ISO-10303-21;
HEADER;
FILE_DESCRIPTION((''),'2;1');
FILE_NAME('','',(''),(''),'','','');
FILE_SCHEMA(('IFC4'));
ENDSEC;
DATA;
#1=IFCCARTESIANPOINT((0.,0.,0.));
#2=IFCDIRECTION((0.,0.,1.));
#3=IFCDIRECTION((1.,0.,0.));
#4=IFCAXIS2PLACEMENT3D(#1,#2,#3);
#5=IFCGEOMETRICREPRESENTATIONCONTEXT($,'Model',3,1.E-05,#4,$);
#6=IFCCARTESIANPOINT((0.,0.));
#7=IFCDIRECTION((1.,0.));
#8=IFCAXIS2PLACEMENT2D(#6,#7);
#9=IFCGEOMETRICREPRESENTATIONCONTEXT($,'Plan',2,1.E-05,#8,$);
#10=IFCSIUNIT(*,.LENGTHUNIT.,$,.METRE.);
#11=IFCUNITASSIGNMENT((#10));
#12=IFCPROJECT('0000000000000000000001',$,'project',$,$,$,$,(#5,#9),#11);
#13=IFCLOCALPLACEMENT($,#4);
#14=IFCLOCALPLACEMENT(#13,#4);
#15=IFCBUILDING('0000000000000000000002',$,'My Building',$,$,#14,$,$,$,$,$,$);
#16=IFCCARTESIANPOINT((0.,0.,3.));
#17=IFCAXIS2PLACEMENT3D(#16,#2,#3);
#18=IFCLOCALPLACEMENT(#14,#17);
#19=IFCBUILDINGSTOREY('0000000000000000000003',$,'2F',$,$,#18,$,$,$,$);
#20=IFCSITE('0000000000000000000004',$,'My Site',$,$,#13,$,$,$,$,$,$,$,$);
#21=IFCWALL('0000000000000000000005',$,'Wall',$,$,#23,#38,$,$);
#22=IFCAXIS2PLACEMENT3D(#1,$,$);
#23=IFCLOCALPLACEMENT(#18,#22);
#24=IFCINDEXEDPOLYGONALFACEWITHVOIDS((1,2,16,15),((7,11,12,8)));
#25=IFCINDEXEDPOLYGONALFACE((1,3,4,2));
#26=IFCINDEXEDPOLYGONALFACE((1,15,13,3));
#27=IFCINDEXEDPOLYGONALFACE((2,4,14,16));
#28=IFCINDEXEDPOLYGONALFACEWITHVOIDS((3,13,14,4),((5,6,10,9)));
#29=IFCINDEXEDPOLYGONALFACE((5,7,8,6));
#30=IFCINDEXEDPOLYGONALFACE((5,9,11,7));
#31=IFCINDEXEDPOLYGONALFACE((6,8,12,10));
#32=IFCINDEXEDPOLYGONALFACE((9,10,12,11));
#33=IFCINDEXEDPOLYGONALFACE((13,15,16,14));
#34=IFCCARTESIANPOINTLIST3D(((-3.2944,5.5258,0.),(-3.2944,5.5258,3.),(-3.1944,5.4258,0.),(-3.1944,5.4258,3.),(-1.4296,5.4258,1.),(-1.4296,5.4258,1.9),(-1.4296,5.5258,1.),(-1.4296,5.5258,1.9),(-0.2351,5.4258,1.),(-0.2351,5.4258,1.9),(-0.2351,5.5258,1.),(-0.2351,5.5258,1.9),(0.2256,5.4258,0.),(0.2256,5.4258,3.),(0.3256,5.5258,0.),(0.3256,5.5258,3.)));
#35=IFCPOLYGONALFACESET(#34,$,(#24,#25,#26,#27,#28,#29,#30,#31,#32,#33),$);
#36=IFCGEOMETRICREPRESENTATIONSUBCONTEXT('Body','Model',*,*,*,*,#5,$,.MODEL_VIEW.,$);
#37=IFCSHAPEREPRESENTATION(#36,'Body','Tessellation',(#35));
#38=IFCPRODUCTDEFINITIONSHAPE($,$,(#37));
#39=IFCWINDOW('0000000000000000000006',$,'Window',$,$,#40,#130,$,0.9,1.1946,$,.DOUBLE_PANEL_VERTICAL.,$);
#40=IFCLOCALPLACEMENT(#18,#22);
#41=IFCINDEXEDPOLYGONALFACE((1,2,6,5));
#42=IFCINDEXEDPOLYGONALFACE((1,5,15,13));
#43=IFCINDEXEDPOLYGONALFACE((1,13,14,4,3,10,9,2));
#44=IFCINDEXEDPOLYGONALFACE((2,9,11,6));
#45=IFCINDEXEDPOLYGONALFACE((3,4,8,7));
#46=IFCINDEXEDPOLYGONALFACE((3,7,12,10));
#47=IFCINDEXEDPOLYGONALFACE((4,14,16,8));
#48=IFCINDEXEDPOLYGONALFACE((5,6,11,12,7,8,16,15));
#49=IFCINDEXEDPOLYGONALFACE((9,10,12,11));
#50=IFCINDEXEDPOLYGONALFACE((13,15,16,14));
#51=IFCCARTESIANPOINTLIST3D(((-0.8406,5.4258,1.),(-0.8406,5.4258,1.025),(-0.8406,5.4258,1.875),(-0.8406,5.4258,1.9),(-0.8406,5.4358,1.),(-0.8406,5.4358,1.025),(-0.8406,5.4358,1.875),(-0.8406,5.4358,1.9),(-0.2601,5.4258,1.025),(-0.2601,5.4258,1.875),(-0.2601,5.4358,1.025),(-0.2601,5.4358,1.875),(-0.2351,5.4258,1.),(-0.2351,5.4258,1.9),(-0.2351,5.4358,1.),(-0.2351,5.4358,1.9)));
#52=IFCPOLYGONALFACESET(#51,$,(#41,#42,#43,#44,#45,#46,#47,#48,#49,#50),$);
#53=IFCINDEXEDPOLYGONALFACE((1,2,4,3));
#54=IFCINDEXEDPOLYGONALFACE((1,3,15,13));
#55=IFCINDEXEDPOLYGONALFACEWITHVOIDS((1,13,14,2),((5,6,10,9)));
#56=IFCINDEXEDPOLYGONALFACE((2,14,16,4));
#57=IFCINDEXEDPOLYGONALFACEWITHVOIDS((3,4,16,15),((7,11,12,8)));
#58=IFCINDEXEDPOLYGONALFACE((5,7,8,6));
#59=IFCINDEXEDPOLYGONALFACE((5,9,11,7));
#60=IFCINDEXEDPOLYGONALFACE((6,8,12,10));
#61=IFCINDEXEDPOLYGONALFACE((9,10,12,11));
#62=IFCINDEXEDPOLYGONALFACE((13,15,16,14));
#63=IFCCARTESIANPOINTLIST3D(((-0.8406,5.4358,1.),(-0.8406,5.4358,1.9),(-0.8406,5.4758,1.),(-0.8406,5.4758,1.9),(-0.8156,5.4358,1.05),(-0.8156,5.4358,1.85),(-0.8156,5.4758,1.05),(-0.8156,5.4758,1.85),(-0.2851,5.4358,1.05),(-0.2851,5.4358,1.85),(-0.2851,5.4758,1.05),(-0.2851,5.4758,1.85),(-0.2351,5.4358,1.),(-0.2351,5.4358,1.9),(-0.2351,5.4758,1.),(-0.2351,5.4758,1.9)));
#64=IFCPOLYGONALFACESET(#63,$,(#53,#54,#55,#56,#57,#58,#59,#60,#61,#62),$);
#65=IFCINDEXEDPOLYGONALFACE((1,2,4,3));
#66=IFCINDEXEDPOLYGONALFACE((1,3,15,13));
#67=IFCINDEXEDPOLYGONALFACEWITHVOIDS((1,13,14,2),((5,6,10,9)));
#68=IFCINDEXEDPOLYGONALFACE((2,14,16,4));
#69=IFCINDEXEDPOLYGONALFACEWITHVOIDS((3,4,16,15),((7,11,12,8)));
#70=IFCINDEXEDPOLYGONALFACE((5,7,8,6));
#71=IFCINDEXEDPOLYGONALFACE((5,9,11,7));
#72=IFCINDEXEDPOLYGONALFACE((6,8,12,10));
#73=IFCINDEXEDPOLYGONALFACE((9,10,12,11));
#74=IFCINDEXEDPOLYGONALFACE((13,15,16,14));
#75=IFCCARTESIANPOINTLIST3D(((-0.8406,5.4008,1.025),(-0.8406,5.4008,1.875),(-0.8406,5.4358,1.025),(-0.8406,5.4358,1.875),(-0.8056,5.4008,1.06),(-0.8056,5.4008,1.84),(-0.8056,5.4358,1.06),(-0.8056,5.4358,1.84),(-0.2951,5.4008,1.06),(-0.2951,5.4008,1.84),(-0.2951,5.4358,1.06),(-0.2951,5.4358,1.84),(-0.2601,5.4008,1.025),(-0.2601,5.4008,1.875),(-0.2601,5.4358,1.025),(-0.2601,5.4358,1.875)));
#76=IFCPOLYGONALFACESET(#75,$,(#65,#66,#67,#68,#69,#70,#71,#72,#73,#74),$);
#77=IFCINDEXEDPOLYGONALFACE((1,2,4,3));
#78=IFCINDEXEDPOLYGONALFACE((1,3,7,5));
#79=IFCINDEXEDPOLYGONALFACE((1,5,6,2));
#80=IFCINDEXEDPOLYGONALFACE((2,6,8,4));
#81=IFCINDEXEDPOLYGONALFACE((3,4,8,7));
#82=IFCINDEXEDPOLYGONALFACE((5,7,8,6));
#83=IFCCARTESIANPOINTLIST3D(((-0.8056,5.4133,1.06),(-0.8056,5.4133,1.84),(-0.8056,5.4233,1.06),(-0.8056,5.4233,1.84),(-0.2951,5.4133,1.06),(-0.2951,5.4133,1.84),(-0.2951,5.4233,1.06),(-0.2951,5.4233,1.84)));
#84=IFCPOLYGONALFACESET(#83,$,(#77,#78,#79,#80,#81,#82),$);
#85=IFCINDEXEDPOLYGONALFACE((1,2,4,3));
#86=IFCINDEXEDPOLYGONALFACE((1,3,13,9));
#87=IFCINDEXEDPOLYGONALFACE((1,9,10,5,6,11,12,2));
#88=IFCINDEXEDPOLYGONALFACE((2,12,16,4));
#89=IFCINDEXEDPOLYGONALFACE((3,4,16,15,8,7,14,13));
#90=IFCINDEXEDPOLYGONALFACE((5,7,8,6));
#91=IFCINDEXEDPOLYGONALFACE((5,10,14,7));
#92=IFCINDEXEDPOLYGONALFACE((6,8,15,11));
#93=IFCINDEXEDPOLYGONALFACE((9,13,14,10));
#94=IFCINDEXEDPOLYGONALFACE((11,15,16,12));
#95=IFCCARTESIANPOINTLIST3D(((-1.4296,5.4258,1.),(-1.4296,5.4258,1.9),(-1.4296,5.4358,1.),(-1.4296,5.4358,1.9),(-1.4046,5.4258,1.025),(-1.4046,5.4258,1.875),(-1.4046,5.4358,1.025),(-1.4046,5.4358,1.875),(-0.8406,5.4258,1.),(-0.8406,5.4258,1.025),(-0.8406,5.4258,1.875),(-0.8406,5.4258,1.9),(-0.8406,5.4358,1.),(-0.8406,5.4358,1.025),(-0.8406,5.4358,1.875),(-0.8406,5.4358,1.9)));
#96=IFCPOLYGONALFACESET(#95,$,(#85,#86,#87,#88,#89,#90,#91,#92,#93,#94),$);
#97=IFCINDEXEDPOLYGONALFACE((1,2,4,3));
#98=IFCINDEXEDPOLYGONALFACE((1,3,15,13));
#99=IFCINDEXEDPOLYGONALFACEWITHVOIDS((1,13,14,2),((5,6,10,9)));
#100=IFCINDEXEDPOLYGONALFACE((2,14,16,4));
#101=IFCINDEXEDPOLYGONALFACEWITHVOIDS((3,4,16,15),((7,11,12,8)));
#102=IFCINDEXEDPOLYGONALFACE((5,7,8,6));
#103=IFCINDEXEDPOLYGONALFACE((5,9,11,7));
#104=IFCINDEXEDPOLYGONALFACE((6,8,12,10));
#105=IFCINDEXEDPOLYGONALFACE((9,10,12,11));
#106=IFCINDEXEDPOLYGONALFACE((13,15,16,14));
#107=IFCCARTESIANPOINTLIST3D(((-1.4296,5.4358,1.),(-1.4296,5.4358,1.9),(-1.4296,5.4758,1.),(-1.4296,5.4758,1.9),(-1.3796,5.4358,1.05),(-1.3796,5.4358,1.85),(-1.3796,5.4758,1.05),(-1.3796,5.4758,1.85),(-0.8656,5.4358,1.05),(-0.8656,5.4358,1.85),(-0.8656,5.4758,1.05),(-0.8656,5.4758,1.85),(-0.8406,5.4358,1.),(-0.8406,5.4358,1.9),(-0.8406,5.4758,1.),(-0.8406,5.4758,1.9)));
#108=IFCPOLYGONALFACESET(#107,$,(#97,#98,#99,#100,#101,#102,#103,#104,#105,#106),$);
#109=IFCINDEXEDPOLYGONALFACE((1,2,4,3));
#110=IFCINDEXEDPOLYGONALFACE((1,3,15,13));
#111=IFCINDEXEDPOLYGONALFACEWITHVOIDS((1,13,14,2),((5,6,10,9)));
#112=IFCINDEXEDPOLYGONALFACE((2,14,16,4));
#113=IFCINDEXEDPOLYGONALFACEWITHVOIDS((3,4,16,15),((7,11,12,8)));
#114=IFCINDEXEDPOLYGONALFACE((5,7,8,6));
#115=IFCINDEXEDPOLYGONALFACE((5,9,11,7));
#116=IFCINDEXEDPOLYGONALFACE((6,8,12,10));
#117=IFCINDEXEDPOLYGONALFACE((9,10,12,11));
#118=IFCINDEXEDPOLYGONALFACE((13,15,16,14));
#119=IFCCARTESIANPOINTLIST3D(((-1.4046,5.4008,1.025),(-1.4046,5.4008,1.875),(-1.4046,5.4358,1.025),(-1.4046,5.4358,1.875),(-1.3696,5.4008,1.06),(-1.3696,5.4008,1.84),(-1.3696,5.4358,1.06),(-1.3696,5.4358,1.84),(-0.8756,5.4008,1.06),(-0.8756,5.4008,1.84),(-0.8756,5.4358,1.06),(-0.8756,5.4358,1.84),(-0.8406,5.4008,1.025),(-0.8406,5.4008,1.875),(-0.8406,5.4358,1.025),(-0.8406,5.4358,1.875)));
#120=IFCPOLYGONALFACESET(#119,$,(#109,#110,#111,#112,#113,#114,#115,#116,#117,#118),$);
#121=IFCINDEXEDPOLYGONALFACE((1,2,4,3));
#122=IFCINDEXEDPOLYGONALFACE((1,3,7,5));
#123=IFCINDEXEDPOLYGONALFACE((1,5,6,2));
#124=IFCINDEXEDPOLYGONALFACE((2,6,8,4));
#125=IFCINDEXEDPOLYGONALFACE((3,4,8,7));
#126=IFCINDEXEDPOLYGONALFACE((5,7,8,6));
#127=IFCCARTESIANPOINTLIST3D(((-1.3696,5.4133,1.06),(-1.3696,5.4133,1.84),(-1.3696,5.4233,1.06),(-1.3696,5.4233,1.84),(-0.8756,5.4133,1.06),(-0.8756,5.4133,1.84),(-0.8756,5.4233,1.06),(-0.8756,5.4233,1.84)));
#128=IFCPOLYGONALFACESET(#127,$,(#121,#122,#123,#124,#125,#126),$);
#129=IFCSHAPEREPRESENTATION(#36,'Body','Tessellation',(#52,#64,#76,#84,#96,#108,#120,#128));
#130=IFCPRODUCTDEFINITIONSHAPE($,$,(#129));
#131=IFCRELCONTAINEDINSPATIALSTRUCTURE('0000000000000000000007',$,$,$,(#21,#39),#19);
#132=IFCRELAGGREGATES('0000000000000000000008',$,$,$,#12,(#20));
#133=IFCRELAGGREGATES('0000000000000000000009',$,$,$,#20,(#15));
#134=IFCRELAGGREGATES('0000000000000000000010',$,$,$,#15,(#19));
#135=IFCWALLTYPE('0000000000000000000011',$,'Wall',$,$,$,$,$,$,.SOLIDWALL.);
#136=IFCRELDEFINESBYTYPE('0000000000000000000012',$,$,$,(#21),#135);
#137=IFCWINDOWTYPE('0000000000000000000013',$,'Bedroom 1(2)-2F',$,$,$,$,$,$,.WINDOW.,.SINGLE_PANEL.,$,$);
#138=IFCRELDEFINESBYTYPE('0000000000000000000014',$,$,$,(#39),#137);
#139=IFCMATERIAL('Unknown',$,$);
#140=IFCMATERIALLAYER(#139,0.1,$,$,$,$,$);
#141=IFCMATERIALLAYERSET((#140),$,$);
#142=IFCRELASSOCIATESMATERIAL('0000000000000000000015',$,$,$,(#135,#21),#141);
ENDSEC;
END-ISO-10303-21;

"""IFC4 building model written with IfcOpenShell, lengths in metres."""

from ifc_helpers import new_model, entity, si_unit, frame, origin_with_axes, origin_2d_with_axis, place, context, subcontext, project, spatial, line, indexed_curve, outline, extrude, shape, source, transform, mapped, material, layer, layer_set, layer_usage, type_object, type_shapes, element, fill, save


model = new_model("IFC4")

# Units and contexts
model_context = context("Model", 3, precision=1e-05, world=origin_with_axes())
plan_context = context("Plan", 2, precision=1e-05, world=origin_2d_with_axis())
body_context_1 = subcontext(model_context, "Body", "Model", "MODEL_VIEW")
body_context_2 = subcontext(plan_context, "Body", "Plan", "PLAN_VIEW")
ifc_project = project(units=[si_unit("LENGTHUNIT", "METRE")], contexts=[model_context, plan_context])

# Site, building, storey
site_placement = place(None, origin_with_axes())
site = spatial("IfcSite", under=ifc_project, at=site_placement, Name="My Site")
building_placement = place(site_placement, origin_with_axes())
building = spatial("IfcBuilding", under=site, at=building_placement, Name="My Building")
storey_placement = place(building_placement, frame((0.0, 0.0, 3.0), z_axis=(0.0, 0.0, 1.0), x_axis=(1.0, 0.0, 0.0)))
storey = spatial("IfcBuildingStorey", under=building, at=storey_placement, Name="2F")

# Shared definitions
ifc_material = material(Name="Unknown")

# Shared definitions
ifc_layer = layer(ifc_material, 0.1)
ifc_layer_set = layer_set([ifc_layer])
wall_type = type_object("IfcWallType", Name="Wall", PredefinedType="SOLIDWALL", material=ifc_layer_set)

# Wall, opening, window
ifc_layer_usage_1 = layer_usage(ifc_layer_set, "AXIS2", "POSITIVE", 0.0)
wall_1_placement = place(storey_placement, frame((0.2256, 5.5258, 0.0), z_axis=(0.0, 0.0, 1.0), x_axis=(-1.0, 0.0, 0.0)))
wall_1 = element("IfcWall", 1, at=wall_1_placement, inside=storey, type_object=wall_type, material=ifc_layer_usage_1, Name="Wall", context=body_context_1, shape_type="SweptSolid", body=[
    extrude(outline(indexed_curve([(-0.1, 0.0), (0.0, 0.1), (3.42, 0.1), (3.52, 0.0)], segments=[line(1, 2, 3, 4, 1)])), origin_with_axes(), (0.0, 0.0, 1.0), 3.0),
])
shared_shape_1 = source(origin_with_axes(), body_context_1, "Body", "SweptSolid", [
    extrude(outline(indexed_curve([(0.0, 0.0), (1.1946, 0.0), (1.1946, 0.9), (0.0, 0.9)], segments=[line(1, 2, 3, 4, 1)])), frame((0.0, -0.6, 0.0), z_axis=(0.0, -1.0, 0.0), x_axis=(1.0, 0.0, 0.0)), (0.0, 0.0, -1.0), 1.2),
])
opening_1_placement = place(wall_1_placement, frame((0.4607, 0.0, 1.0), z_axis=(0.0, 0.0, 1.0), x_axis=(1.0, 0.0, 0.0)))
opening_1 = element("IfcOpeningElement", 2, at=opening_1_placement, cuts=wall_1, PredefinedType="OPENING", context=body_context_1, shape_type="MappedRepresentation", body=[
    mapped(shared_shape_1, transform((0.0, 0.0, 0.0), x_axis=(1.0, 0.0, 0.0), y_axis=(0.0, 1.0, 0.0), z_axis=(0.0, 0.0, 1.0), scale=1.0)),
])
window_type_1 = type_object("IfcWindowType", Name="Bedroom 1(2)-2F", PartitioningType="SINGLE_PANEL", PredefinedType="WINDOW")
shared_shape_2 = source(origin_with_axes(), body_context_1, "Body", "SweptSolid", [
    extrude(outline(indexed_curve([(0.6056, 0.0), (0.0, 0.0), (0.0, 0.9), (0.6056, 0.9), (0.6056, 0.875), (0.025, 0.875), (0.025, 0.025), (0.6056, 0.025)], segments=[line(1, 2, 3, 4, 5, 6, 7, 8, 1)])), frame((0.0, 0.09, 0.0), z_axis=(0.0, -1.0, 0.0), x_axis=(1.0, 0.0, 0.0)), (0.0, 0.0, -1.0), 0.01),
    extrude(outline(indexed_curve([(0.0, 0.0), (0.6056, 0.0), (0.6056, 0.9), (0.0, 0.9)], segments=[line(1, 2, 3, 4, 1)]), holes=[indexed_curve([(0.05, 0.05), (0.5806, 0.05), (0.5806, 0.85), (0.05, 0.85)], segments=[line(1, 2, 3, 4, 1)])]), frame((0.0, 0.05, 0.0), z_axis=(0.0, -1.0, 0.0), x_axis=(1.0, 0.0, 0.0)), (0.0, 0.0, -1.0), 0.04),
    extrude(outline(indexed_curve([(0.0, 0.0), (0.5806, 0.0), (0.5806, 0.85), (0.0, 0.85)], segments=[line(1, 2, 3, 4, 1)]), holes=[indexed_curve([(0.035, 0.035), (0.5456, 0.035), (0.5456, 0.815), (0.035, 0.815)], segments=[line(1, 2, 3, 4, 1)])]), frame((0.025, 0.09, 0.025), z_axis=(0.0, -1.0, 0.0), x_axis=(1.0, 0.0, 0.0)), (0.0, 0.0, -1.0), 0.035),
    extrude(outline(indexed_curve([(0.035, 0.035), (0.5456, 0.035), (0.5456, 0.815), (0.035, 0.815)], segments=[line(1, 2, 3, 4, 1)])), frame((0.025, 0.1025, 0.025), z_axis=(0.0, -1.0, 0.0), x_axis=(1.0, 0.0, 0.0)), (0.0, 0.0, -1.0), 0.01),
    extrude(outline(indexed_curve([(0.0, 0.9), (0.589, 0.9), (0.589, 0.0), (0.0, 0.0), (0.0, 0.025), (0.564, 0.025), (0.564, 0.875), (0.0, 0.875)], segments=[line(1, 2, 3, 4, 5, 6, 7, 8, 1)])), frame((0.6056, 0.09, 0.0), z_axis=(0.0, -1.0, 0.0), x_axis=(1.0, 0.0, 0.0)), (0.0, 0.0, -1.0), 0.01),
    extrude(outline(indexed_curve([(0.0, 0.0), (0.589, 0.0), (0.589, 0.9), (0.0, 0.9)], segments=[line(1, 2, 3, 4, 1)]), holes=[indexed_curve([(0.025, 0.05), (0.539, 0.05), (0.539, 0.85), (0.025, 0.85)], segments=[line(1, 2, 3, 4, 1)])]), frame((0.6056, 0.05, 0.0), z_axis=(0.0, -1.0, 0.0), x_axis=(1.0, 0.0, 0.0)), (0.0, 0.0, -1.0), 0.04),
    extrude(outline(indexed_curve([(0.0, 0.0), (0.564, 0.0), (0.564, 0.85), (0.0, 0.85)], segments=[line(1, 2, 3, 4, 1)]), holes=[indexed_curve([(0.035, 0.035), (0.529, 0.035), (0.529, 0.815), (0.035, 0.815)], segments=[line(1, 2, 3, 4, 1)])]), frame((0.6056, 0.09, 0.025), z_axis=(0.0, -1.0, 0.0), x_axis=(1.0, 0.0, 0.0)), (0.0, 0.0, -1.0), 0.035),
    extrude(outline(indexed_curve([(0.035, 0.035), (0.529, 0.035), (0.529, 0.815), (0.035, 0.815)], segments=[line(1, 2, 3, 4, 1)])), frame((0.6056, 0.1025, 0.025), z_axis=(0.0, -1.0, 0.0), x_axis=(1.0, 0.0, 0.0)), (0.0, 0.0, -1.0), 0.01),
])
shared_shape_3 = source(origin_with_axes(), body_context_2, "Body", "Curve2D", [
    entity("IfcIndexedPolyCurve", entity("IfcCartesianPointList2D", [[0.05, 0.05], [0.5806, 0.05]])),
    entity("IfcIndexedPolyCurve", entity("IfcCartesianPointList2D", [[0.0, 0.1], [0.025, 0.1], [0.025, 0.09], [0.05, 0.09], [0.05, 0.05], [0.0, 0.05]]), [entity("IfcLineIndex", [1, 2, 3, 4, 5, 6, 1])]),
    entity("IfcIndexedPolyCurve", entity("IfcCartesianPointList2D", [[0.6056, 0.1], [0.6056, 0.1], [0.6056, 0.09], [0.5806, 0.09], [0.5806, 0.05], [0.6056, 0.05]])),
    entity("IfcIndexedPolyCurve", entity("IfcCartesianPointList2D", [[0.025, 0.09], [0.06, 0.09], [0.06, 0.125], [0.025, 0.125]]), [entity("IfcLineIndex", [1, 2, 3, 4, 1])]),
    entity("IfcIndexedPolyCurve", entity("IfcCartesianPointList2D", [[0.6056, 0.09], [0.5706, 0.09], [0.5706, 0.125], [0.6056, 0.125]]), [entity("IfcLineIndex", [1, 2, 3, 4, 1])]),
    entity("IfcIndexedPolyCurve", entity("IfcCartesianPointList2D", [[0.06, 0.09], [0.5706, 0.09]])),
    entity("IfcIndexedPolyCurve", entity("IfcCartesianPointList2D", [[0.06, 0.125], [0.5706, 0.125]])),
    entity("IfcIndexedPolyCurve", entity("IfcCartesianPointList2D", [[0.06, 0.1075], [0.5706, 0.1075]])),
    entity("IfcIndexedPolyCurve", entity("IfcCartesianPointList2D", [[0.6306, 0.05], [1.1446, 0.05]])),
    entity("IfcIndexedPolyCurve", entity("IfcCartesianPointList2D", [[0.6056, 0.1], [0.6056, 0.1], [0.6056, 0.09], [0.6306, 0.09], [0.6306, 0.05], [0.6056, 0.05]])),
    entity("IfcIndexedPolyCurve", entity("IfcCartesianPointList2D", [[1.1946, 0.1], [1.1696, 0.1], [1.1696, 0.09], [1.1446, 0.09], [1.1446, 0.05], [1.1946, 0.05]]), [entity("IfcLineIndex", [1, 2, 3, 4, 5, 6, 1])]),
    entity("IfcIndexedPolyCurve", entity("IfcCartesianPointList2D", [[0.6056, 0.09], [0.6406, 0.09], [0.6406, 0.125], [0.6056, 0.125]]), [entity("IfcLineIndex", [1, 2, 3, 4, 1])]),
    entity("IfcIndexedPolyCurve", entity("IfcCartesianPointList2D", [[1.1696, 0.09], [1.1346, 0.09], [1.1346, 0.125], [1.1696, 0.125]]), [entity("IfcLineIndex", [1, 2, 3, 4, 1])]),
    entity("IfcIndexedPolyCurve", entity("IfcCartesianPointList2D", [[0.6406, 0.09], [1.1346, 0.09]])),
    entity("IfcIndexedPolyCurve", entity("IfcCartesianPointList2D", [[0.6406, 0.125], [1.1346, 0.125]])),
    entity("IfcIndexedPolyCurve", entity("IfcCartesianPointList2D", [[0.6406, 0.1075], [1.1346, 0.1075]])),
])
type_shapes(window_type_1, [shared_shape_2, shared_shape_3])
window_1_placement = place(opening_1_placement, frame((0.0, 0.0, 0.0), z_axis=(0.0, 0.0, 1.0), x_axis=(1.0, 0.0, 0.0)))
window_1 = element("IfcWindow", 3, at=window_1_placement, inside=storey, type_object=window_type_1, Name="Window", OverallHeight=0.9, OverallWidth=1.1946, PartitioningType="DOUBLE_PANEL_VERTICAL", shapes=[
    shape(body_context_1, "Body", "MappedRepresentation", [mapped(shared_shape_2, transform((0.0, 0.0, 0.0), x_axis=(1.0, 0.0, 0.0), y_axis=(0.0, 1.0, 0.0), z_axis=(0.0, 0.0, 1.0), scale=1.0))]),
    shape(body_context_2, "Body", "MappedRepresentation", [mapped(shared_shape_3, transform((0.0, 0.0, 0.0), x_axis=(1.0, 0.0, 0.0), y_axis=(0.0, 1.0, 0.0), z_axis=(0.0, 0.0, 1.0), scale=1.0))]),
])
fill(opening_1, window_1)

save(model, "model.ifc")
